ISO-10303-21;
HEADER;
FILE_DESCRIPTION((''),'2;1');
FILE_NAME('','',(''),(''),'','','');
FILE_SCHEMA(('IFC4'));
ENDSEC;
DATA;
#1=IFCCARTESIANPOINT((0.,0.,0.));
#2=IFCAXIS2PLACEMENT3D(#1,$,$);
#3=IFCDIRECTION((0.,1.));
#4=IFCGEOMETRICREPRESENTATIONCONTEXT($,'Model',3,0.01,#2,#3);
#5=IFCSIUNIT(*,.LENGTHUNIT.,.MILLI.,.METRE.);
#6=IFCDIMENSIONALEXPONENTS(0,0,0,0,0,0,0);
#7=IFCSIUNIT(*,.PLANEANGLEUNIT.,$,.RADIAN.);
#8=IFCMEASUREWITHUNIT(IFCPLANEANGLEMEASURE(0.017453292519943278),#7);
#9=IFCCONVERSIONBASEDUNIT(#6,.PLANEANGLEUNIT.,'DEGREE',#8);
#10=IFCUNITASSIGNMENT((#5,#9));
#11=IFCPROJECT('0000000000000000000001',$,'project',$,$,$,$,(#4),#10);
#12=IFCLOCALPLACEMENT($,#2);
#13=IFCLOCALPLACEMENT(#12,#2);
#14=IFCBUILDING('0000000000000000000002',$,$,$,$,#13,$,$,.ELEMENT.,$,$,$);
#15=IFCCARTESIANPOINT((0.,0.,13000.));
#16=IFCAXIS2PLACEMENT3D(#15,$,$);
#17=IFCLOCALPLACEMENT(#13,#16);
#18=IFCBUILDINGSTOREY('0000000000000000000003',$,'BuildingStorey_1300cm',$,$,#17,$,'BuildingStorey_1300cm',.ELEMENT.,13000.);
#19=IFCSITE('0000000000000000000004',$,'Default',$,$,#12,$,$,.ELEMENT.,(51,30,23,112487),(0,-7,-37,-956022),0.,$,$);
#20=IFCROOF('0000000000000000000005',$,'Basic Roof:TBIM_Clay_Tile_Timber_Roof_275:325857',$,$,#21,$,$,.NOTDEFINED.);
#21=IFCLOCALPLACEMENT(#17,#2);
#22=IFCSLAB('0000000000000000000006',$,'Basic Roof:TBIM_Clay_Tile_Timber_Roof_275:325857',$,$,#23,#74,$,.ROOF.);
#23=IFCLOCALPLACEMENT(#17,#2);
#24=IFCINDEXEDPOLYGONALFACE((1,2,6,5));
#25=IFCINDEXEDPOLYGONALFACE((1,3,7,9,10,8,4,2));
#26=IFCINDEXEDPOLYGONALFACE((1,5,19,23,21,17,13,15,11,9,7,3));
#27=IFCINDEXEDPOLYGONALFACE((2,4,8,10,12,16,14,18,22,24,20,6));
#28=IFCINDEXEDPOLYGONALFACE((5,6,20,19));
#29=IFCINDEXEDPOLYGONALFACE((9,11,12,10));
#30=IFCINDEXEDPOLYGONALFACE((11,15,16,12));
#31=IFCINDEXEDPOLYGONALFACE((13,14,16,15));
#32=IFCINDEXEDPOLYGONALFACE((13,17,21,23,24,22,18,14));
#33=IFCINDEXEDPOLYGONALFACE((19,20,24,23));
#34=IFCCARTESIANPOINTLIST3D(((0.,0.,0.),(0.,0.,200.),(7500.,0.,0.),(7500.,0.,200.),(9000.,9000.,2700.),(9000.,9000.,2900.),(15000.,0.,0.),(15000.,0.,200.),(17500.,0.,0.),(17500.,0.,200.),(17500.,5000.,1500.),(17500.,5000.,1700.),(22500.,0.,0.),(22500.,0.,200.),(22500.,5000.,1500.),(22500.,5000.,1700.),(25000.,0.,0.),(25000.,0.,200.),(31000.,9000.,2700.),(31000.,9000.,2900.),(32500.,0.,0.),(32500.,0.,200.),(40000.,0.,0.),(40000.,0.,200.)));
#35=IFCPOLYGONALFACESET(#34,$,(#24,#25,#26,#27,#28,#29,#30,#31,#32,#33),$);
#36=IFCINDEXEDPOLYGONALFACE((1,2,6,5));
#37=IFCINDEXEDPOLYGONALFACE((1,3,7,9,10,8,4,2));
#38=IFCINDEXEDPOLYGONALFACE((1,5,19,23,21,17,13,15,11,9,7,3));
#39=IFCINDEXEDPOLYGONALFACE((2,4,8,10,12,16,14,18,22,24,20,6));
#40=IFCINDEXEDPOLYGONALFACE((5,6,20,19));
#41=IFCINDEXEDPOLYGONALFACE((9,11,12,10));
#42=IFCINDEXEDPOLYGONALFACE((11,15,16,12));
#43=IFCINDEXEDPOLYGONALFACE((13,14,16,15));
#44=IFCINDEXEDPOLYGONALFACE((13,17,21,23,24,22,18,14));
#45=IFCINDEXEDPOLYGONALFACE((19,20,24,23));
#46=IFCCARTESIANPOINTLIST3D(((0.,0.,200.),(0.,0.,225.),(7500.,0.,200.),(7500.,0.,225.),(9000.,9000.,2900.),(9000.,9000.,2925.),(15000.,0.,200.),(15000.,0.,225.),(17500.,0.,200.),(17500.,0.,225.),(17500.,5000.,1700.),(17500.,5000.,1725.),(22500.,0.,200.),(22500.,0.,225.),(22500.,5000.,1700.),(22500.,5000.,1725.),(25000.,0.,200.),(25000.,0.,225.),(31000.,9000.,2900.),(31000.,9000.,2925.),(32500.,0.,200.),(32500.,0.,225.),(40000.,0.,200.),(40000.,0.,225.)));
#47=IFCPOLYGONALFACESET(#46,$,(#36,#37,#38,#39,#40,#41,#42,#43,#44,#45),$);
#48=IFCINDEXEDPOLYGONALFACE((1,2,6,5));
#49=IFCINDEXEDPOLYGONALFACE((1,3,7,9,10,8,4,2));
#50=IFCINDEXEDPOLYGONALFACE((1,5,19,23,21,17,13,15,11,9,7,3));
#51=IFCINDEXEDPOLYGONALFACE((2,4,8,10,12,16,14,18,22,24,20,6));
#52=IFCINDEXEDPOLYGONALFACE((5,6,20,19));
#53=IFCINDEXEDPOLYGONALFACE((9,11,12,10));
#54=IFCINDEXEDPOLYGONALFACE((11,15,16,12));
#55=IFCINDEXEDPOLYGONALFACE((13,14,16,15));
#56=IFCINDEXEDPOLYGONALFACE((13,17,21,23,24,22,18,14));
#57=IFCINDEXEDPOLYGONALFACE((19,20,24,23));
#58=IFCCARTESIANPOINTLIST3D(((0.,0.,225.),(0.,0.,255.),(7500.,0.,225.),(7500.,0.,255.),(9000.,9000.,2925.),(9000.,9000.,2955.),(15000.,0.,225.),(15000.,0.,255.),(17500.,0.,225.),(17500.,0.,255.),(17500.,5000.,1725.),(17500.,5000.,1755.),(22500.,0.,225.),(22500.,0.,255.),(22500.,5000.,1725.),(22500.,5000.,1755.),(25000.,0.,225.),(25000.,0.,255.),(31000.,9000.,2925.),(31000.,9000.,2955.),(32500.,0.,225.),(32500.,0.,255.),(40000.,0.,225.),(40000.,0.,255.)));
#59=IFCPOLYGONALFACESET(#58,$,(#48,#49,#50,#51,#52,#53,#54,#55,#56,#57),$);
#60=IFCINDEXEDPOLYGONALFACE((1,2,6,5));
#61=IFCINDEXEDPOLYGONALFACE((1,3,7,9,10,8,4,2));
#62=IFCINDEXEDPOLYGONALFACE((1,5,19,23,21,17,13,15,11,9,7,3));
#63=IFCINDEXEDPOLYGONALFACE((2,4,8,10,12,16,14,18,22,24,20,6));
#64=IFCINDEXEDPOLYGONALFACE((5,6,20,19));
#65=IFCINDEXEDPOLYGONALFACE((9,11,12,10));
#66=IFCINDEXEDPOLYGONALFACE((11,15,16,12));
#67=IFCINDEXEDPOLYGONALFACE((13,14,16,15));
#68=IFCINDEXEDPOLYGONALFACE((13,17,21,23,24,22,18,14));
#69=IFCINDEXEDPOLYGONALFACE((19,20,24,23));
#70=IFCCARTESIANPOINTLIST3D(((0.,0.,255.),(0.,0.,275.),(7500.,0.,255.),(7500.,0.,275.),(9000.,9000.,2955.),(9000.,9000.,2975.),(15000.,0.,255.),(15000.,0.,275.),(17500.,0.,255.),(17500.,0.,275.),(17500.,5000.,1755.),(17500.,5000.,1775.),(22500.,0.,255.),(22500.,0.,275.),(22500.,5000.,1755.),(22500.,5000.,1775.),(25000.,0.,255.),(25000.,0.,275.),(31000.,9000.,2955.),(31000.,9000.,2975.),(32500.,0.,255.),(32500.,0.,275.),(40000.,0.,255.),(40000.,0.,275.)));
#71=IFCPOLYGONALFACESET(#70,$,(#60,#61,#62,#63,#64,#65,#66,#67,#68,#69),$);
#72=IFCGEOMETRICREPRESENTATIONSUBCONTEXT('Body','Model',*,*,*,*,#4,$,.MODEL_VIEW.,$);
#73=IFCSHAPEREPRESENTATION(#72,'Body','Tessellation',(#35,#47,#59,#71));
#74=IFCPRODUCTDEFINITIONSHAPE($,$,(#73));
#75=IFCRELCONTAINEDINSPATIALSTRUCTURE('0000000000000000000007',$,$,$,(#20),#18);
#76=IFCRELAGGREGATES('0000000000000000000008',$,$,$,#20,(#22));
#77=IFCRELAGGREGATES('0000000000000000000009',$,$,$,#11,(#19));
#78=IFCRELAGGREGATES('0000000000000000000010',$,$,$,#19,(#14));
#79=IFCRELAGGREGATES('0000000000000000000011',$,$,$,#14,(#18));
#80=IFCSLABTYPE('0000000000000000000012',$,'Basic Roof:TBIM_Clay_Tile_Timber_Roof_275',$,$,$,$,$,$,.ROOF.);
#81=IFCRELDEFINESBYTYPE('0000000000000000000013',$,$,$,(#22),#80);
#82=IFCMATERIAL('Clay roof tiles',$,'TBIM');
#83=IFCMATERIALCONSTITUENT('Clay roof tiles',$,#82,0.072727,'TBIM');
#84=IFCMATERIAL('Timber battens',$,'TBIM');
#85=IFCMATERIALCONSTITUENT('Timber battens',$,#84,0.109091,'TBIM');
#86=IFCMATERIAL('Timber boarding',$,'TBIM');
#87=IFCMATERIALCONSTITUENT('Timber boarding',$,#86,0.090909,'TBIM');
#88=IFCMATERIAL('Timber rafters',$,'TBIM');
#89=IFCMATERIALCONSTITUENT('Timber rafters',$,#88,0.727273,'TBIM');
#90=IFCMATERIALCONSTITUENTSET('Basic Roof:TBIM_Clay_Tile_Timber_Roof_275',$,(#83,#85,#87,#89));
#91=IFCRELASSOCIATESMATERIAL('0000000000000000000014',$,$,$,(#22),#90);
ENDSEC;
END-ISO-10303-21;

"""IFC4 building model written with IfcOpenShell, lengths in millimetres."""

from ifc_helpers import new_model, entity, si_unit, converted_unit, direction, frame, origin, place, context, subcontext, project, spatial, indexed_curve, outline, extrude, material, constituent, constituent_set, type_object, element, aggregate, save


model = new_model("IFC4")

# Units and contexts
model_context = context("Model", 3, precision=0.01, world=origin(), true_north=direction((0.0, 1.0)))
body_context = subcontext(model_context, "Body", "Model", "MODEL_VIEW")
ifc_project = project(units=[si_unit("LENGTHUNIT", "METRE", prefix="MILLI"), converted_unit("PLANEANGLEUNIT", "DEGREE", entity("IfcPlaneAngleMeasure", 0.017453292519943278), si_unit("PLANEANGLEUNIT", "RADIAN"), dimensions=[0, 0, 0, 0, 0, 0, 0])], contexts=[model_context])

# Site, building, storey
site_placement = place(None, origin())
site = spatial("IfcSite", under=ifc_project, at=site_placement, Name="Default", CompositionType="ELEMENT", RefLatitude=(51, 30, 23, 112487), RefLongitude=(0, -7, -37, -956022), RefElevation=0.0)
building_placement = place(site_placement, origin())
building = spatial("IfcBuilding", under=site, at=building_placement, CompositionType="ELEMENT")
storey_placement = place(building_placement, frame((0.0, 0.0, 13000.0)))
storey = spatial("IfcBuildingStorey", under=building, at=storey_placement, Name="BuildingStorey_1300cm", LongName="BuildingStorey_1300cm", CompositionType="ELEMENT", Elevation=13000.0)

# Roof, slab
roof_1_placement = place(storey_placement, origin())
roof_1 = element("IfcRoof", 1, at=roof_1_placement, inside=storey, Name="Basic Roof:TBIM_Clay_Tile_Timber_Roof_275:325857", PredefinedType="NOTDEFINED")
ifc_material_1 = material(Name="Clay roof tiles", Category="TBIM")
ifc_constituent_1 = constituent(ifc_material_1, Name="Clay roof tiles", Category="TBIM", fraction=0.072727)
ifc_material_2 = material(Name="Timber battens", Category="TBIM")
ifc_constituent_2 = constituent(ifc_material_2, Name="Timber battens", Category="TBIM", fraction=0.109091)
ifc_material_3 = material(Name="Timber boarding", Category="TBIM")
ifc_constituent_3 = constituent(ifc_material_3, Name="Timber boarding", Category="TBIM", fraction=0.090909)
ifc_material_4 = material(Name="Timber rafters", Category="TBIM")
ifc_constituent_4 = constituent(ifc_material_4, Name="Timber rafters", Category="TBIM", fraction=0.727273)
ifc_constituent_set_1 = constituent_set(constituents=[ifc_constituent_1, ifc_constituent_2, ifc_constituent_3, ifc_constituent_4], Name="Basic Roof:TBIM_Clay_Tile_Timber_Roof_275")
slab_type_1 = type_object("IfcSlabType", Name="Basic Roof:TBIM_Clay_Tile_Timber_Roof_275", PredefinedType="ROOF")
slab_1_placement = place(roof_1_placement, origin())
slab_1 = element("IfcSlab", 2, at=slab_1_placement, type_object=slab_type_1, material=ifc_constituent_set_1, Name="Basic Roof:TBIM_Clay_Tile_Timber_Roof_275:325857", PredefinedType="ROOF", context=body_context, shape_type="SweptSolid", body=[
    extrude(outline(indexed_curve([(11000.0, 4698.1), (-11000.0, 4698.1), (-20000.0, -4698.1), (-12500.0, -4698.1), (-5000.0, -4698.1), (-2500.0, -4698.1), (-2500.0, 522.0), (2500.0, 522.0), (2500.0, -4698.1), (5000.0, -4698.1), (12500.0, -4698.1), (20000.0, -4698.1), (11000.0, 4698.1)], self_intersect=False)), frame((20000.0, 4500.0, 1350.0), z_axis=(0.0, -0.287348, 0.957826), x_axis=(1.0, 0.0, 0.0)), (0.0, 0.287348, 0.957826), 200.0),
    extrude(outline(indexed_curve([(11000.0, 4698.1), (-11000.0, 4698.1), (-20000.0, -4698.1), (-12500.0, -4698.1), (-5000.0, -4698.1), (-2500.0, -4698.1), (-2500.0, 522.0), (2500.0, 522.0), (2500.0, -4698.1), (5000.0, -4698.1), (12500.0, -4698.1), (20000.0, -4698.1), (11000.0, 4698.1)], self_intersect=False)), frame((20000.0, 4500.0, 1550.0), z_axis=(0.0, -0.287348, 0.957826), x_axis=(1.0, 0.0, 0.0)), (0.0, 0.287348, 0.957826), 25.0),
    extrude(outline(indexed_curve([(11000.0, 4698.1), (-11000.0, 4698.1), (-20000.0, -4698.1), (-12500.0, -4698.1), (-5000.0, -4698.1), (-2500.0, -4698.1), (-2500.0, 522.0), (2500.0, 522.0), (2500.0, -4698.1), (5000.0, -4698.1), (12500.0, -4698.1), (20000.0, -4698.1), (11000.0, 4698.1)], self_intersect=False)), frame((20000.0, 4500.0, 1575.0), z_axis=(0.0, -0.287348, 0.957826), x_axis=(1.0, 0.0, 0.0)), (0.0, 0.287348, 0.957826), 30.0),
    extrude(outline(indexed_curve([(11000.0, 4698.1), (-11000.0, 4698.1), (-20000.0, -4698.1), (-12500.0, -4698.1), (-5000.0, -4698.1), (-2500.0, -4698.1), (-2500.0, 522.0), (2500.0, 522.0), (2500.0, -4698.1), (5000.0, -4698.1), (12500.0, -4698.1), (20000.0, -4698.1), (11000.0, 4698.1)], self_intersect=False)), frame((20000.0, 4500.0, 1605.0), z_axis=(0.0, -0.287348, 0.957826), x_axis=(1.0, 0.0, 0.0)), (0.0, 0.287348, 0.957826), 20.0),
])
aggregate(roof_1, [slab_1])

save(model, "model.ifc")
